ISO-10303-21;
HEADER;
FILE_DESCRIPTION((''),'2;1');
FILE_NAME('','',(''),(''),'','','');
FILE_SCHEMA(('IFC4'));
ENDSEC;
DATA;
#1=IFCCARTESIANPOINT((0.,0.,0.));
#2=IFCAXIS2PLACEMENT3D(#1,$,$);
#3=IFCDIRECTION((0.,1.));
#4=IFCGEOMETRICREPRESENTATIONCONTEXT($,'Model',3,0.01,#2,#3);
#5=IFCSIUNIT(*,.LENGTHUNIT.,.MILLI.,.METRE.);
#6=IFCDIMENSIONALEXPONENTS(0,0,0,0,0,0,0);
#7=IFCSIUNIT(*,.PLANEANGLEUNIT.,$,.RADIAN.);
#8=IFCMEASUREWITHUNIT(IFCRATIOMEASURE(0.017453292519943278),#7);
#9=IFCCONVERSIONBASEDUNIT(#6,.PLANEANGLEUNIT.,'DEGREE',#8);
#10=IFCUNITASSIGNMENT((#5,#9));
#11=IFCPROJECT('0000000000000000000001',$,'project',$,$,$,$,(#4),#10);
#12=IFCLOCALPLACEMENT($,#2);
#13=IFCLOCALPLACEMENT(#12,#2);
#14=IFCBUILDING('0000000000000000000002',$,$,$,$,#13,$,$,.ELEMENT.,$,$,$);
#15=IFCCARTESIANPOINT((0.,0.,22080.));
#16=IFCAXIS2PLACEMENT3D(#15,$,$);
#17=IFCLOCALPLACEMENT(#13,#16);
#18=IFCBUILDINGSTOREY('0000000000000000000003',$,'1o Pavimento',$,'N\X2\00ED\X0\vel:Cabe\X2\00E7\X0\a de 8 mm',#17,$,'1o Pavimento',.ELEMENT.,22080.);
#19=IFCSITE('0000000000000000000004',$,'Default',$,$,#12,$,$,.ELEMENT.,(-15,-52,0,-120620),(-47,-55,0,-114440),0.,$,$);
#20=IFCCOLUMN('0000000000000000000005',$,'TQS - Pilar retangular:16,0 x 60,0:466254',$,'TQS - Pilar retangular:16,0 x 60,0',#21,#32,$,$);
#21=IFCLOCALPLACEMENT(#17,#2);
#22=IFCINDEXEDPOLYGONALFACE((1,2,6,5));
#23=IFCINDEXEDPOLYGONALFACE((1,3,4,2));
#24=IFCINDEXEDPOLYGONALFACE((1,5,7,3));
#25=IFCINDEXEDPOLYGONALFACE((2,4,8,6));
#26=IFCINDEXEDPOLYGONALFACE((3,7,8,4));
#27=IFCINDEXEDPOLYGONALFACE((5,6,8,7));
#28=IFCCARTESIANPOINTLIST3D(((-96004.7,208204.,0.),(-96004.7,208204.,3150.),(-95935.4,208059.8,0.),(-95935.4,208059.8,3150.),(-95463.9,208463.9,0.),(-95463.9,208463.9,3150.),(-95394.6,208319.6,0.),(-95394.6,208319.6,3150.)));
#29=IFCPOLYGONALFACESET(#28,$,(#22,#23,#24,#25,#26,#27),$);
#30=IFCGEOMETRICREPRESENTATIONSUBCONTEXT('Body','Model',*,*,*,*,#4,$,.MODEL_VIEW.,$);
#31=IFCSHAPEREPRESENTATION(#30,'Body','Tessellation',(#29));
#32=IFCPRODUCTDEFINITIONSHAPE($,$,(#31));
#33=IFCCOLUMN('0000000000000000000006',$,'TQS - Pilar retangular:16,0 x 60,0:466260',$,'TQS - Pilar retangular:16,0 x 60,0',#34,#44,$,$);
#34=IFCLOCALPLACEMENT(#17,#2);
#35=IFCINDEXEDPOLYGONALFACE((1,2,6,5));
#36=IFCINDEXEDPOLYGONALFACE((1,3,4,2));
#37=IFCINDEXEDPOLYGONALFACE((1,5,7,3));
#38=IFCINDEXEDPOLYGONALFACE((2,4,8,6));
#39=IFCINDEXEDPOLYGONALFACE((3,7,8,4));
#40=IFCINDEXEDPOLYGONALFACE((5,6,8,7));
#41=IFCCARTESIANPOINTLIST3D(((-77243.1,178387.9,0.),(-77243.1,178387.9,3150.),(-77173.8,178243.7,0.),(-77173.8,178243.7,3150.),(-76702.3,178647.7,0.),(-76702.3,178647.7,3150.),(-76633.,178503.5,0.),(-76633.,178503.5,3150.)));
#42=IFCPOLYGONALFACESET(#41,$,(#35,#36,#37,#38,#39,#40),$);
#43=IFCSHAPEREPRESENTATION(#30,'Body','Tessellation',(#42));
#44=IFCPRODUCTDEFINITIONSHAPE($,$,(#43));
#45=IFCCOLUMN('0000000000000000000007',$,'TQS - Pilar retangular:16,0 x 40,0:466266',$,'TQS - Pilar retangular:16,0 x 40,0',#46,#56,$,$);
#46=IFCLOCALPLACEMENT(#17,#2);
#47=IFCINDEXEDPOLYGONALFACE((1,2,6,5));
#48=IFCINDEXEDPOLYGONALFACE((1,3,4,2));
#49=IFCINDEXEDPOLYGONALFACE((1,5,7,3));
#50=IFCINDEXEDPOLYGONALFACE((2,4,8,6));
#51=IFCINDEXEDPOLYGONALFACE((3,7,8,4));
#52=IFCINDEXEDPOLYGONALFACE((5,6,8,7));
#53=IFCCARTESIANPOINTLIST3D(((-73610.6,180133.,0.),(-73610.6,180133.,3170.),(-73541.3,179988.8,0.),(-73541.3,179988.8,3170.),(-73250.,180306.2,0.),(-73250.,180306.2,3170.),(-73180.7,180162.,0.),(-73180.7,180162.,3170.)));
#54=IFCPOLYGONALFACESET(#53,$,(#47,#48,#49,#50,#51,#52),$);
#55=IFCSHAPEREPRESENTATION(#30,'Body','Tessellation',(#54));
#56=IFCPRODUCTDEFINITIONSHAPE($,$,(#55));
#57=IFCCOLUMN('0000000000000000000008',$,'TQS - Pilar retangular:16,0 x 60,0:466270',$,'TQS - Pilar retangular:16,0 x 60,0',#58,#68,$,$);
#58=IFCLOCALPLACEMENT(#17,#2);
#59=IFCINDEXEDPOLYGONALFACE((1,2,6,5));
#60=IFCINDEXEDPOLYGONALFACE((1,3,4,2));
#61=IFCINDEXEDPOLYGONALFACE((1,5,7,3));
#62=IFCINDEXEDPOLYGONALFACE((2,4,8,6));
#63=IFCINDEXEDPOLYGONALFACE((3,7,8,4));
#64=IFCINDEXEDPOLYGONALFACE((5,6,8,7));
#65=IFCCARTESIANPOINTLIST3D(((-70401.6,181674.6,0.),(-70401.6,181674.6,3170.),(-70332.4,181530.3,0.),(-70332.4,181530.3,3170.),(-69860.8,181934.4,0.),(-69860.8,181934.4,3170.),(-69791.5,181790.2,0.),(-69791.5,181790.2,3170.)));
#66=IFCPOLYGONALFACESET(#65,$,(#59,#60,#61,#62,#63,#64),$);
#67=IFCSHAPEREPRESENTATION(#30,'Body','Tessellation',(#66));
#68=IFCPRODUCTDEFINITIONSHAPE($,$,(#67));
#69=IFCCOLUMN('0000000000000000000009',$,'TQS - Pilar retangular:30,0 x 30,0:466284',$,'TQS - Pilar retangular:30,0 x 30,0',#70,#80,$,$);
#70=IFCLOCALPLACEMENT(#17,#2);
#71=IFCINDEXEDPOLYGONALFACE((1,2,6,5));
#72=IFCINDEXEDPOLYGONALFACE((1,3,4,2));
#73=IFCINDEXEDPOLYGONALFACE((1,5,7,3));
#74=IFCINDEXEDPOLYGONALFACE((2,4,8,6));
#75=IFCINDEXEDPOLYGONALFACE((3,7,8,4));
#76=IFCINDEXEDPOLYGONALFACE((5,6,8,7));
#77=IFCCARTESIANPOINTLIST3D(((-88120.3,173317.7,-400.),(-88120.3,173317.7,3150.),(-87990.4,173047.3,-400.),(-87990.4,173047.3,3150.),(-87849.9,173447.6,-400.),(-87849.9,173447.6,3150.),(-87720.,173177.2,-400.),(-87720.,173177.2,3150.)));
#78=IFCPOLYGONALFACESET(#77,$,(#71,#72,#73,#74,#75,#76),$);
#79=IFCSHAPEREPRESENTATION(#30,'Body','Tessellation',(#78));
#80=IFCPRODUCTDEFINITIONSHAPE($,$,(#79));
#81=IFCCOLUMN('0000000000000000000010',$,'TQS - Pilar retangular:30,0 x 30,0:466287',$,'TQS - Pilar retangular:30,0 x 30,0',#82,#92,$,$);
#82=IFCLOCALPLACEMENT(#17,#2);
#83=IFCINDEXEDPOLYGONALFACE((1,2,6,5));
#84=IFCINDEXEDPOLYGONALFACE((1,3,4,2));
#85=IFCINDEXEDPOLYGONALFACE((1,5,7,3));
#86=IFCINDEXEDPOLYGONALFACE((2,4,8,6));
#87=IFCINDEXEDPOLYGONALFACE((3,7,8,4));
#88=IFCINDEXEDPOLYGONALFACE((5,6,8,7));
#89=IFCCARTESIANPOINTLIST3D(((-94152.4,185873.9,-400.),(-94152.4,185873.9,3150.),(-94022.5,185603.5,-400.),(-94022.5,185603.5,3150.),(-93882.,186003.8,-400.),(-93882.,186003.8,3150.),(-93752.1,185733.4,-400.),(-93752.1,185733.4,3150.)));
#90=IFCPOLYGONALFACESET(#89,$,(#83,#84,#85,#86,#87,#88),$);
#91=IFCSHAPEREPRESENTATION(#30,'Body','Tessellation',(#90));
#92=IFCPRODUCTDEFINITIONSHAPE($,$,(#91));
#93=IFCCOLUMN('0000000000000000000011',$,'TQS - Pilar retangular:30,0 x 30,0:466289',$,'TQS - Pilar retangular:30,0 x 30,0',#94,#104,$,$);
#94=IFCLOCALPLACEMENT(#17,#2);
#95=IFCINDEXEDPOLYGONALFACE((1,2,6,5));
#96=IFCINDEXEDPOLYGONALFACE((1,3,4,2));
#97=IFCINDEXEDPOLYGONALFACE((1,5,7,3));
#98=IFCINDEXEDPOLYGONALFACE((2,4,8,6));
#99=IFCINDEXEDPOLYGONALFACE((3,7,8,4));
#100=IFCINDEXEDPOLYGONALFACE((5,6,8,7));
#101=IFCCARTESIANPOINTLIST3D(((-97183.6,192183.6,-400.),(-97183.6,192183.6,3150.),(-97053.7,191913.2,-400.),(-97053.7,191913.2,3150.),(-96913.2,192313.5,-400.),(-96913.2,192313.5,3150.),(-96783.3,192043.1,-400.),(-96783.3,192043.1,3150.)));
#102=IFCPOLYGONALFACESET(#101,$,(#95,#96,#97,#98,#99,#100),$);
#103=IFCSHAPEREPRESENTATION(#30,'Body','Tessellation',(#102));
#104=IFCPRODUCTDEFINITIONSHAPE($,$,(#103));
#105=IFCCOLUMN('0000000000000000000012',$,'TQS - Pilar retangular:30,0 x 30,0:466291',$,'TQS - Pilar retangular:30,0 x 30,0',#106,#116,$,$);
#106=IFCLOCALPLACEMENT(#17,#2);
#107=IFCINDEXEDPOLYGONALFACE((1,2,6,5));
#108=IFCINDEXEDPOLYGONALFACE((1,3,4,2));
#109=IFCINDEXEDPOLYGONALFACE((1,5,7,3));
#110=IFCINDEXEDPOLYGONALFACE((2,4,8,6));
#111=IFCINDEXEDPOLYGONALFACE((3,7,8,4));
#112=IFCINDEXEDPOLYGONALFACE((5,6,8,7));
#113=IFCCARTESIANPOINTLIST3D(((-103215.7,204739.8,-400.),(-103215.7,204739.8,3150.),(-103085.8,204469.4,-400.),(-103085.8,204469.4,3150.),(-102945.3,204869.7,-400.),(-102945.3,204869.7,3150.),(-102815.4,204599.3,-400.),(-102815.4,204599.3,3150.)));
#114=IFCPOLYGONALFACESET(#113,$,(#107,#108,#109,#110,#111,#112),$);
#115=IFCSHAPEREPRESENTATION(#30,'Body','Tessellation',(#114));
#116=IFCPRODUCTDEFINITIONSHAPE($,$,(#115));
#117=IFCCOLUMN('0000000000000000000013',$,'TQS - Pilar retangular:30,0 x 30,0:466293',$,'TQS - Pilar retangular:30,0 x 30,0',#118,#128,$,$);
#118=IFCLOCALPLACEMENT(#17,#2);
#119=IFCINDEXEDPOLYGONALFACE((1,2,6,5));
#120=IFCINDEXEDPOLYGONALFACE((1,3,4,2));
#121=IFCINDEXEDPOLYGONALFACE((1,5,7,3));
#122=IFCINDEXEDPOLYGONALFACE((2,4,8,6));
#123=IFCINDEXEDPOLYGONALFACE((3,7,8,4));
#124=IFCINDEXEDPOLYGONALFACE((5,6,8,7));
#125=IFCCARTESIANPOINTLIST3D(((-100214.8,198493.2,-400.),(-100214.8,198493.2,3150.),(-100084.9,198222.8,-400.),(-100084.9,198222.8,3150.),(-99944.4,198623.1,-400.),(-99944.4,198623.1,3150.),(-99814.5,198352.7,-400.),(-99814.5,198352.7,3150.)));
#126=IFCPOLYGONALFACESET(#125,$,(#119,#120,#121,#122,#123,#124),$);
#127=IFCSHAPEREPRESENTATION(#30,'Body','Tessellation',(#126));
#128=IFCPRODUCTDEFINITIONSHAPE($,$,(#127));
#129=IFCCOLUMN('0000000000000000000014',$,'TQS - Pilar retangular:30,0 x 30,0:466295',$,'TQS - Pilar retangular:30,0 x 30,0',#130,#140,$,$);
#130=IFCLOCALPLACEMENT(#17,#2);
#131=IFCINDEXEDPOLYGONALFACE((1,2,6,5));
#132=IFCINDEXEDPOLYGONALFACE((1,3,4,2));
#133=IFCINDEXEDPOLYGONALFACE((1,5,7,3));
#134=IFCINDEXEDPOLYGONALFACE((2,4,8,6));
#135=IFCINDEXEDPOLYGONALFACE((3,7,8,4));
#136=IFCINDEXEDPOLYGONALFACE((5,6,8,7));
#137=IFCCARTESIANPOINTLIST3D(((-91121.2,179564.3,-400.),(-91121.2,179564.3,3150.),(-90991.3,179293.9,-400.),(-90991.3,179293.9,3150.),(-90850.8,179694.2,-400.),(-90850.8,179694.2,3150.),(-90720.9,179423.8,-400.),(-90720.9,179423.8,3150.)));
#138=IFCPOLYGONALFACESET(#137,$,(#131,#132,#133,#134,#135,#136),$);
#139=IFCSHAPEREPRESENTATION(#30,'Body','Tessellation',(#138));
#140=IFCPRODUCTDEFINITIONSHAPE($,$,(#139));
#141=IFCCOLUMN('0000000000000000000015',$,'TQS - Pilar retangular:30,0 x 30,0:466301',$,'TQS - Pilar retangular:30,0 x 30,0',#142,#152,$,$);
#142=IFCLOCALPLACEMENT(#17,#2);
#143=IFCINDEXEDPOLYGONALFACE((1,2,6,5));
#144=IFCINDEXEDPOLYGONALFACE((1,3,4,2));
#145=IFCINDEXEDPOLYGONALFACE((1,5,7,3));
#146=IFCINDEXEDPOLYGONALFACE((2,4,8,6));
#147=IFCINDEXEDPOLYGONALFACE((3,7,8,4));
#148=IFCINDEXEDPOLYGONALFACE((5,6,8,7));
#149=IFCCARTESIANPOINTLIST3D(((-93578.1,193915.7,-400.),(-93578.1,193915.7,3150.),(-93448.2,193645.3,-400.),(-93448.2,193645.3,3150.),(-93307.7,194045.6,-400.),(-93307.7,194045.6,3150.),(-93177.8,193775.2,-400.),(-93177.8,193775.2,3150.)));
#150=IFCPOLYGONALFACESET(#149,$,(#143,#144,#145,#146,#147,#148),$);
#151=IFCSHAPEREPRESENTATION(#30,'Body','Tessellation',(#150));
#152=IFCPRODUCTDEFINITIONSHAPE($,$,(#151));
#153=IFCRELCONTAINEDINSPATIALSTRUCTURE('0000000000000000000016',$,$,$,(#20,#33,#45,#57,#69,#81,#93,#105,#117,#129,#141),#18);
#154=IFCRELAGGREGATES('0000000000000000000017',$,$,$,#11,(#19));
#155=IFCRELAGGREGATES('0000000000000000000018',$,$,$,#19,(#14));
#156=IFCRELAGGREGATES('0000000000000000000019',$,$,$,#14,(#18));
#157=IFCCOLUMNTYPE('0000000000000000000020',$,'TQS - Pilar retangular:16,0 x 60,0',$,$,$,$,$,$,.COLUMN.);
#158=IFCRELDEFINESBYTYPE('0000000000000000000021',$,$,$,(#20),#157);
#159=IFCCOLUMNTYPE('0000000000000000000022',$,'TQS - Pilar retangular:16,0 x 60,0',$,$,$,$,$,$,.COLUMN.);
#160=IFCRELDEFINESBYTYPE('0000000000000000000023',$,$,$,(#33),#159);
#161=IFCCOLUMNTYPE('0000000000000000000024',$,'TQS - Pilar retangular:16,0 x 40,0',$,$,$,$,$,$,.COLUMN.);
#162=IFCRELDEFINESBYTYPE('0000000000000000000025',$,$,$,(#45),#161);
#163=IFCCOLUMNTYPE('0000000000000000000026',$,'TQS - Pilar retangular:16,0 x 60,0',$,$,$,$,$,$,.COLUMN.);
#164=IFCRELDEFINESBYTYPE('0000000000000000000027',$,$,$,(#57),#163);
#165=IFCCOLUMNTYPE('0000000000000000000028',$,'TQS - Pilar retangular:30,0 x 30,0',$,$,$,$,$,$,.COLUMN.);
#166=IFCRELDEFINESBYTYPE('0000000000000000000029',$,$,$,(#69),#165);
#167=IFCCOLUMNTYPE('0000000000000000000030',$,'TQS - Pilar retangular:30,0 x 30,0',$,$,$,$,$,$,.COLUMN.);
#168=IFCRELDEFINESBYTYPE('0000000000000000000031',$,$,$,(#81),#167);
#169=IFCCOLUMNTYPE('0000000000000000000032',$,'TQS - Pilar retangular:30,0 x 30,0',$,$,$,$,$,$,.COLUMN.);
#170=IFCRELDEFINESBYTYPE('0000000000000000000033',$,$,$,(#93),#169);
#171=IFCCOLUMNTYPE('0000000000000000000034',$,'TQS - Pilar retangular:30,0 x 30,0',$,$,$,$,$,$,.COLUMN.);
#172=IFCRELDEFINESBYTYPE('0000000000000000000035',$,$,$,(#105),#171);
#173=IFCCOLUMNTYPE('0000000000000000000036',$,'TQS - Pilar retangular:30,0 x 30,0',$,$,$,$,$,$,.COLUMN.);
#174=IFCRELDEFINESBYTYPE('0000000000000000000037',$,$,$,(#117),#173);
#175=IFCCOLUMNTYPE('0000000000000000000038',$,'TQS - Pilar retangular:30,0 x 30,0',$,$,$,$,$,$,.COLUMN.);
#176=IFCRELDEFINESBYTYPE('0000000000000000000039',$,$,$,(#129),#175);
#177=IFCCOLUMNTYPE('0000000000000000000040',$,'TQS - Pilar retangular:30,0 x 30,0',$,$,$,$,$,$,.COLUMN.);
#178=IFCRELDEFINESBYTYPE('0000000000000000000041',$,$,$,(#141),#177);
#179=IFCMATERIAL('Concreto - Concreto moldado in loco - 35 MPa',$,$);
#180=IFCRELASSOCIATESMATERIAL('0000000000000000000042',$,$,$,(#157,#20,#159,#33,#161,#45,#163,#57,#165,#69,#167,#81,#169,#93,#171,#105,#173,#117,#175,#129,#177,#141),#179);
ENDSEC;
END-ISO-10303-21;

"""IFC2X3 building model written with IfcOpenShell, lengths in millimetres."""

from ifc_helpers import new_model, entity, si_unit, converted_unit, direction, frame, origin, origin_2d_with_axis, place, context, subcontext, project, spatial, rectangle, extrude, source, transform, mapped, material, type_object, type_shapes, element, save


model = new_model("IFC2X3")

# Units and contexts
model_context = context("Model", 3, precision=0.01, world=origin(), true_north=direction((0.0, 1.0)))
body_context = subcontext(model_context, "Body", "Model", "MODEL_VIEW")
ifc_project = project(units=[si_unit("LENGTHUNIT", "METRE", prefix="MILLI"), converted_unit("PLANEANGLEUNIT", "DEGREE", entity("IfcRatioMeasure", 0.017453292519943278), si_unit("PLANEANGLEUNIT", "RADIAN"), dimensions=[0, 0, 0, 0, 0, 0, 0])], contexts=[model_context])

# Site, building, storey
site_placement = place(None, origin())
site = spatial("IfcSite", under=ifc_project, at=site_placement, Name="Default", CompositionType="ELEMENT", RefLatitude=(-15, -52, 0, -120620), RefLongitude=(-47, -55, 0, -114440), RefElevation=0.0)
building_placement = place(site_placement, origin())
building = spatial("IfcBuilding", under=site, at=building_placement, CompositionType="ELEMENT")
storey_placement = place(building_placement, frame((0.0, 0.0, 22080.0)))
storey = spatial("IfcBuildingStorey", under=building, at=storey_placement, Name="1o Pavimento", ObjectType="Nível:Cabeça de 8 mm", LongName="1o Pavimento", CompositionType="ELEMENT", Elevation=22080.0)

# Columns
ifc_material = material(Name="Concreto - Concreto moldado in loco - 35 MPa")
column_type_1 = type_object("IfcColumnType", Name="TQS - Pilar retangular:16,0 x 60,0", PredefinedType="COLUMN", material=ifc_material)
shared_shape_1 = source(origin(), body_context, "Body", "SweptSolid", [
    extrude(rectangle(XDim=600.0, YDim=160.0, at=origin_2d_with_axis()), frame((-95699.6, 208261.8, 22080.0), z_axis=(0.0, 0.0, 1.0), x_axis=(-0.90138, -0.43303, 0.0)), (0.0, 0.0, 1.0), 3150.0),
])
type_shapes(column_type_1, [shared_shape_1])
column_1_placement = place(storey_placement, frame((0.0, 0.0, -22080.0)))
element("IfcColumn", 1, at=column_1_placement, inside=storey, type_object=column_type_1, material=ifc_material, Name="TQS - Pilar retangular:16,0 x 60,0:466254", ObjectType="TQS - Pilar retangular:16,0 x 60,0", context=body_context, shape_type="MappedRepresentation", body=[
    mapped(shared_shape_1, transform((0.0, 0.0, 0.0), scale=1.0)),
])
column_type_2 = type_object("IfcColumnType", Name="TQS - Pilar retangular:16,0 x 60,0", PredefinedType="COLUMN", material=ifc_material)
shared_shape_2 = source(origin(), body_context, "Body", "SweptSolid", [
    extrude(rectangle(XDim=600.0, YDim=160.0, at=origin_2d_with_axis()), frame((-76938.1, 178445.7, 22080.0), z_axis=(0.0, 0.0, 1.0), x_axis=(-0.90138, -0.43303, 0.0)), (0.0, 0.0, 1.0), 3150.0),
])
type_shapes(column_type_2, [shared_shape_2])
column_2_placement = place(storey_placement, frame((0.0, 0.0, -22080.0)))
element("IfcColumn", 2, at=column_2_placement, inside=storey, type_object=column_type_2, material=ifc_material, Name="TQS - Pilar retangular:16,0 x 60,0:466260", ObjectType="TQS - Pilar retangular:16,0 x 60,0", context=body_context, shape_type="MappedRepresentation", body=[
    mapped(shared_shape_2, transform((0.0, 0.0, 0.0), scale=1.0)),
])
column_type_3 = type_object("IfcColumnType", Name="TQS - Pilar retangular:16,0 x 40,0", PredefinedType="COLUMN", material=ifc_material)
shared_shape_3 = source(origin(), body_context, "Body", "SweptSolid", [
    extrude(rectangle(XDim=400.0, YDim=160.0, at=origin_2d_with_axis()), frame((-73395.6, 180147.5, 22080.0), z_axis=(0.0, 0.0, 1.0), x_axis=(-0.90138, -0.43303, 0.0)), (0.0, 0.0, 1.0), 3170.0),
])
type_shapes(column_type_3, [shared_shape_3])
column_3_placement = place(storey_placement, frame((0.0, 0.0, -22080.0)))
element("IfcColumn", 3, at=column_3_placement, inside=storey, type_object=column_type_3, material=ifc_material, Name="TQS - Pilar retangular:16,0 x 40,0:466266", ObjectType="TQS - Pilar retangular:16,0 x 40,0", context=body_context, shape_type="MappedRepresentation", body=[
    mapped(shared_shape_3, transform((0.0, 0.0, 0.0), scale=1.0)),
])
column_type_4 = type_object("IfcColumnType", Name="TQS - Pilar retangular:16,0 x 60,0", PredefinedType="COLUMN", material=ifc_material)
shared_shape_4 = source(origin(), body_context, "Body", "SweptSolid", [
    extrude(rectangle(XDim=600.0, YDim=160.0, at=origin_2d_with_axis()), frame((-70096.6, 181732.4, 22080.0), z_axis=(0.0, 0.0, 1.0), x_axis=(-0.90138, -0.43303, 0.0)), (0.0, 0.0, 1.0), 3170.0),
])
type_shapes(column_type_4, [shared_shape_4])
column_4_placement = place(storey_placement, frame((0.0, 0.0, -22080.0)))
element("IfcColumn", 4, at=column_4_placement, inside=storey, type_object=column_type_4, material=ifc_material, Name="TQS - Pilar retangular:16,0 x 60,0:466270", ObjectType="TQS - Pilar retangular:16,0 x 60,0", context=body_context, shape_type="MappedRepresentation", body=[
    mapped(shared_shape_4, transform((0.0, 0.0, 0.0), scale=1.0)),
])
column_type_5 = type_object("IfcColumnType", Name="TQS - Pilar retangular:30,0 x 30,0", PredefinedType="COLUMN", material=ifc_material)
shared_shape_5 = source(origin(), body_context, "Body", "SweptSolid", [
    extrude(rectangle(XDim=300.0, YDim=300.0, at=origin_2d_with_axis()), frame((-87920.1, 173247.5, 21680.0), z_axis=(0.0, 0.0, 1.0), x_axis=(-0.90138, -0.43303, 0.0)), (0.0, 0.0, 1.0), 3550.0),
])
type_shapes(column_type_5, [shared_shape_5])
column_5_placement = place(storey_placement, frame((0.0, 0.0, -22080.0)))
element("IfcColumn", 5, at=column_5_placement, inside=storey, type_object=column_type_5, material=ifc_material, Name="TQS - Pilar retangular:30,0 x 30,0:466284", ObjectType="TQS - Pilar retangular:30,0 x 30,0", context=body_context, shape_type="MappedRepresentation", body=[
    mapped(shared_shape_5, transform((0.0, 0.0, 0.0), scale=1.0)),
])
column_type_6 = type_object("IfcColumnType", Name="TQS - Pilar retangular:30,0 x 30,0", PredefinedType="COLUMN", material=ifc_material)
shared_shape_6 = source(origin(), body_context, "Body", "SweptSolid", [
    extrude(rectangle(XDim=300.0, YDim=300.0, at=origin_2d_with_axis()), frame((-93952.2, 185803.7, 21680.0), z_axis=(0.0, 0.0, 1.0), x_axis=(-0.90138, -0.43303, 0.0)), (0.0, 0.0, 1.0), 3550.0),
])
type_shapes(column_type_6, [shared_shape_6])
column_6_placement = place(storey_placement, frame((0.0, 0.0, -22080.0)))
element("IfcColumn", 6, at=column_6_placement, inside=storey, type_object=column_type_6, material=ifc_material, Name="TQS - Pilar retangular:30,0 x 30,0:466287", ObjectType="TQS - Pilar retangular:30,0 x 30,0", context=body_context, shape_type="MappedRepresentation", body=[
    mapped(shared_shape_6, transform((0.0, 0.0, 0.0), scale=1.0)),
])
column_type_7 = type_object("IfcColumnType", Name="TQS - Pilar retangular:30,0 x 30,0", PredefinedType="COLUMN", material=ifc_material)
shared_shape_7 = source(origin(), body_context, "Body", "SweptSolid", [
    extrude(rectangle(XDim=300.0, YDim=300.0, at=origin_2d_with_axis()), frame((-96983.4, 192113.3, 21680.0), z_axis=(0.0, 0.0, 1.0), x_axis=(-0.90138, -0.43303, 0.0)), (0.0, 0.0, 1.0), 3550.0),
])
type_shapes(column_type_7, [shared_shape_7])
column_7_placement = place(storey_placement, frame((0.0, 0.0, -22080.0)))
element("IfcColumn", 7, at=column_7_placement, inside=storey, type_object=column_type_7, material=ifc_material, Name="TQS - Pilar retangular:30,0 x 30,0:466289", ObjectType="TQS - Pilar retangular:30,0 x 30,0", context=body_context, shape_type="MappedRepresentation", body=[
    mapped(shared_shape_7, transform((0.0, 0.0, 0.0), scale=1.0)),
])
column_type_8 = type_object("IfcColumnType", Name="TQS - Pilar retangular:30,0 x 30,0", PredefinedType="COLUMN", material=ifc_material)
shared_shape_8 = source(origin(), body_context, "Body", "SweptSolid", [
    extrude(rectangle(XDim=300.0, YDim=300.0, at=origin_2d_with_axis()), frame((-103015.6, 204669.5, 21680.0), z_axis=(0.0, 0.0, 1.0), x_axis=(-0.90138, -0.43303, 0.0)), (0.0, 0.0, 1.0), 3550.0),
])
type_shapes(column_type_8, [shared_shape_8])
column_8_placement = place(storey_placement, frame((0.0, 0.0, -22080.0)))
element("IfcColumn", 8, at=column_8_placement, inside=storey, type_object=column_type_8, material=ifc_material, Name="TQS - Pilar retangular:30,0 x 30,0:466291", ObjectType="TQS - Pilar retangular:30,0 x 30,0", context=body_context, shape_type="MappedRepresentation", body=[
    mapped(shared_shape_8, transform((0.0, 0.0, 0.0), scale=1.0)),
])
column_type_9 = type_object("IfcColumnType", Name="TQS - Pilar retangular:30,0 x 30,0", PredefinedType="COLUMN", material=ifc_material)
shared_shape_9 = source(origin(), body_context, "Body", "SweptSolid", [
    extrude(rectangle(XDim=300.0, YDim=300.0, at=origin_2d_with_axis()), frame((-100014.7, 198423.0, 21680.0), z_axis=(0.0, 0.0, 1.0), x_axis=(-0.90138, -0.43303, 0.0)), (0.0, 0.0, 1.0), 3550.0),
])
type_shapes(column_type_9, [shared_shape_9])
column_9_placement = place(storey_placement, frame((0.0, 0.0, -22080.0)))
element("IfcColumn", 9, at=column_9_placement, inside=storey, type_object=column_type_9, material=ifc_material, Name="TQS - Pilar retangular:30,0 x 30,0:466293", ObjectType="TQS - Pilar retangular:30,0 x 30,0", context=body_context, shape_type="MappedRepresentation", body=[
    mapped(shared_shape_9, transform((0.0, 0.0, 0.0), scale=1.0)),
])
column_type_10 = type_object("IfcColumnType", Name="TQS - Pilar retangular:30,0 x 30,0", PredefinedType="COLUMN", material=ifc_material)
shared_shape_10 = source(origin(), body_context, "Body", "SweptSolid", [
    extrude(rectangle(XDim=300.0, YDim=300.0, at=origin_2d_with_axis()), frame((-90921.0, 179494.0, 21680.0), z_axis=(0.0, 0.0, 1.0), x_axis=(-0.90138, -0.43303, 0.0)), (0.0, 0.0, 1.0), 3550.0),
])
type_shapes(column_type_10, [shared_shape_10])
column_10_placement = place(storey_placement, frame((0.0, 0.0, -22080.0)))
element("IfcColumn", 10, at=column_10_placement, inside=storey, type_object=column_type_10, material=ifc_material, Name="TQS - Pilar retangular:30,0 x 30,0:466295", ObjectType="TQS - Pilar retangular:30,0 x 30,0", context=body_context, shape_type="MappedRepresentation", body=[
    mapped(shared_shape_10, transform((0.0, 0.0, 0.0), scale=1.0)),
])
column_type_11 = type_object("IfcColumnType", Name="TQS - Pilar retangular:30,0 x 30,0", PredefinedType="COLUMN", material=ifc_material)
shared_shape_11 = source(origin(), body_context, "Body", "SweptSolid", [
    extrude(rectangle(XDim=300.0, YDim=300.0, at=origin_2d_with_axis()), frame((-93377.9, 193845.4, 21680.0), z_axis=(0.0, 0.0, 1.0), x_axis=(-0.90138, -0.43303, 0.0)), (0.0, 0.0, 1.0), 3550.0),
])
type_shapes(column_type_11, [shared_shape_11])
column_11_placement = place(storey_placement, frame((0.0, 0.0, -22080.0)))
element("IfcColumn", 11, at=column_11_placement, inside=storey, type_object=column_type_11, material=ifc_material, Name="TQS - Pilar retangular:30,0 x 30,0:466301", ObjectType="TQS - Pilar retangular:30,0 x 30,0", context=body_context, shape_type="MappedRepresentation", body=[
    mapped(shared_shape_11, transform((0.0, 0.0, 0.0), scale=1.0)),
])

save(model, "model.ifc")
